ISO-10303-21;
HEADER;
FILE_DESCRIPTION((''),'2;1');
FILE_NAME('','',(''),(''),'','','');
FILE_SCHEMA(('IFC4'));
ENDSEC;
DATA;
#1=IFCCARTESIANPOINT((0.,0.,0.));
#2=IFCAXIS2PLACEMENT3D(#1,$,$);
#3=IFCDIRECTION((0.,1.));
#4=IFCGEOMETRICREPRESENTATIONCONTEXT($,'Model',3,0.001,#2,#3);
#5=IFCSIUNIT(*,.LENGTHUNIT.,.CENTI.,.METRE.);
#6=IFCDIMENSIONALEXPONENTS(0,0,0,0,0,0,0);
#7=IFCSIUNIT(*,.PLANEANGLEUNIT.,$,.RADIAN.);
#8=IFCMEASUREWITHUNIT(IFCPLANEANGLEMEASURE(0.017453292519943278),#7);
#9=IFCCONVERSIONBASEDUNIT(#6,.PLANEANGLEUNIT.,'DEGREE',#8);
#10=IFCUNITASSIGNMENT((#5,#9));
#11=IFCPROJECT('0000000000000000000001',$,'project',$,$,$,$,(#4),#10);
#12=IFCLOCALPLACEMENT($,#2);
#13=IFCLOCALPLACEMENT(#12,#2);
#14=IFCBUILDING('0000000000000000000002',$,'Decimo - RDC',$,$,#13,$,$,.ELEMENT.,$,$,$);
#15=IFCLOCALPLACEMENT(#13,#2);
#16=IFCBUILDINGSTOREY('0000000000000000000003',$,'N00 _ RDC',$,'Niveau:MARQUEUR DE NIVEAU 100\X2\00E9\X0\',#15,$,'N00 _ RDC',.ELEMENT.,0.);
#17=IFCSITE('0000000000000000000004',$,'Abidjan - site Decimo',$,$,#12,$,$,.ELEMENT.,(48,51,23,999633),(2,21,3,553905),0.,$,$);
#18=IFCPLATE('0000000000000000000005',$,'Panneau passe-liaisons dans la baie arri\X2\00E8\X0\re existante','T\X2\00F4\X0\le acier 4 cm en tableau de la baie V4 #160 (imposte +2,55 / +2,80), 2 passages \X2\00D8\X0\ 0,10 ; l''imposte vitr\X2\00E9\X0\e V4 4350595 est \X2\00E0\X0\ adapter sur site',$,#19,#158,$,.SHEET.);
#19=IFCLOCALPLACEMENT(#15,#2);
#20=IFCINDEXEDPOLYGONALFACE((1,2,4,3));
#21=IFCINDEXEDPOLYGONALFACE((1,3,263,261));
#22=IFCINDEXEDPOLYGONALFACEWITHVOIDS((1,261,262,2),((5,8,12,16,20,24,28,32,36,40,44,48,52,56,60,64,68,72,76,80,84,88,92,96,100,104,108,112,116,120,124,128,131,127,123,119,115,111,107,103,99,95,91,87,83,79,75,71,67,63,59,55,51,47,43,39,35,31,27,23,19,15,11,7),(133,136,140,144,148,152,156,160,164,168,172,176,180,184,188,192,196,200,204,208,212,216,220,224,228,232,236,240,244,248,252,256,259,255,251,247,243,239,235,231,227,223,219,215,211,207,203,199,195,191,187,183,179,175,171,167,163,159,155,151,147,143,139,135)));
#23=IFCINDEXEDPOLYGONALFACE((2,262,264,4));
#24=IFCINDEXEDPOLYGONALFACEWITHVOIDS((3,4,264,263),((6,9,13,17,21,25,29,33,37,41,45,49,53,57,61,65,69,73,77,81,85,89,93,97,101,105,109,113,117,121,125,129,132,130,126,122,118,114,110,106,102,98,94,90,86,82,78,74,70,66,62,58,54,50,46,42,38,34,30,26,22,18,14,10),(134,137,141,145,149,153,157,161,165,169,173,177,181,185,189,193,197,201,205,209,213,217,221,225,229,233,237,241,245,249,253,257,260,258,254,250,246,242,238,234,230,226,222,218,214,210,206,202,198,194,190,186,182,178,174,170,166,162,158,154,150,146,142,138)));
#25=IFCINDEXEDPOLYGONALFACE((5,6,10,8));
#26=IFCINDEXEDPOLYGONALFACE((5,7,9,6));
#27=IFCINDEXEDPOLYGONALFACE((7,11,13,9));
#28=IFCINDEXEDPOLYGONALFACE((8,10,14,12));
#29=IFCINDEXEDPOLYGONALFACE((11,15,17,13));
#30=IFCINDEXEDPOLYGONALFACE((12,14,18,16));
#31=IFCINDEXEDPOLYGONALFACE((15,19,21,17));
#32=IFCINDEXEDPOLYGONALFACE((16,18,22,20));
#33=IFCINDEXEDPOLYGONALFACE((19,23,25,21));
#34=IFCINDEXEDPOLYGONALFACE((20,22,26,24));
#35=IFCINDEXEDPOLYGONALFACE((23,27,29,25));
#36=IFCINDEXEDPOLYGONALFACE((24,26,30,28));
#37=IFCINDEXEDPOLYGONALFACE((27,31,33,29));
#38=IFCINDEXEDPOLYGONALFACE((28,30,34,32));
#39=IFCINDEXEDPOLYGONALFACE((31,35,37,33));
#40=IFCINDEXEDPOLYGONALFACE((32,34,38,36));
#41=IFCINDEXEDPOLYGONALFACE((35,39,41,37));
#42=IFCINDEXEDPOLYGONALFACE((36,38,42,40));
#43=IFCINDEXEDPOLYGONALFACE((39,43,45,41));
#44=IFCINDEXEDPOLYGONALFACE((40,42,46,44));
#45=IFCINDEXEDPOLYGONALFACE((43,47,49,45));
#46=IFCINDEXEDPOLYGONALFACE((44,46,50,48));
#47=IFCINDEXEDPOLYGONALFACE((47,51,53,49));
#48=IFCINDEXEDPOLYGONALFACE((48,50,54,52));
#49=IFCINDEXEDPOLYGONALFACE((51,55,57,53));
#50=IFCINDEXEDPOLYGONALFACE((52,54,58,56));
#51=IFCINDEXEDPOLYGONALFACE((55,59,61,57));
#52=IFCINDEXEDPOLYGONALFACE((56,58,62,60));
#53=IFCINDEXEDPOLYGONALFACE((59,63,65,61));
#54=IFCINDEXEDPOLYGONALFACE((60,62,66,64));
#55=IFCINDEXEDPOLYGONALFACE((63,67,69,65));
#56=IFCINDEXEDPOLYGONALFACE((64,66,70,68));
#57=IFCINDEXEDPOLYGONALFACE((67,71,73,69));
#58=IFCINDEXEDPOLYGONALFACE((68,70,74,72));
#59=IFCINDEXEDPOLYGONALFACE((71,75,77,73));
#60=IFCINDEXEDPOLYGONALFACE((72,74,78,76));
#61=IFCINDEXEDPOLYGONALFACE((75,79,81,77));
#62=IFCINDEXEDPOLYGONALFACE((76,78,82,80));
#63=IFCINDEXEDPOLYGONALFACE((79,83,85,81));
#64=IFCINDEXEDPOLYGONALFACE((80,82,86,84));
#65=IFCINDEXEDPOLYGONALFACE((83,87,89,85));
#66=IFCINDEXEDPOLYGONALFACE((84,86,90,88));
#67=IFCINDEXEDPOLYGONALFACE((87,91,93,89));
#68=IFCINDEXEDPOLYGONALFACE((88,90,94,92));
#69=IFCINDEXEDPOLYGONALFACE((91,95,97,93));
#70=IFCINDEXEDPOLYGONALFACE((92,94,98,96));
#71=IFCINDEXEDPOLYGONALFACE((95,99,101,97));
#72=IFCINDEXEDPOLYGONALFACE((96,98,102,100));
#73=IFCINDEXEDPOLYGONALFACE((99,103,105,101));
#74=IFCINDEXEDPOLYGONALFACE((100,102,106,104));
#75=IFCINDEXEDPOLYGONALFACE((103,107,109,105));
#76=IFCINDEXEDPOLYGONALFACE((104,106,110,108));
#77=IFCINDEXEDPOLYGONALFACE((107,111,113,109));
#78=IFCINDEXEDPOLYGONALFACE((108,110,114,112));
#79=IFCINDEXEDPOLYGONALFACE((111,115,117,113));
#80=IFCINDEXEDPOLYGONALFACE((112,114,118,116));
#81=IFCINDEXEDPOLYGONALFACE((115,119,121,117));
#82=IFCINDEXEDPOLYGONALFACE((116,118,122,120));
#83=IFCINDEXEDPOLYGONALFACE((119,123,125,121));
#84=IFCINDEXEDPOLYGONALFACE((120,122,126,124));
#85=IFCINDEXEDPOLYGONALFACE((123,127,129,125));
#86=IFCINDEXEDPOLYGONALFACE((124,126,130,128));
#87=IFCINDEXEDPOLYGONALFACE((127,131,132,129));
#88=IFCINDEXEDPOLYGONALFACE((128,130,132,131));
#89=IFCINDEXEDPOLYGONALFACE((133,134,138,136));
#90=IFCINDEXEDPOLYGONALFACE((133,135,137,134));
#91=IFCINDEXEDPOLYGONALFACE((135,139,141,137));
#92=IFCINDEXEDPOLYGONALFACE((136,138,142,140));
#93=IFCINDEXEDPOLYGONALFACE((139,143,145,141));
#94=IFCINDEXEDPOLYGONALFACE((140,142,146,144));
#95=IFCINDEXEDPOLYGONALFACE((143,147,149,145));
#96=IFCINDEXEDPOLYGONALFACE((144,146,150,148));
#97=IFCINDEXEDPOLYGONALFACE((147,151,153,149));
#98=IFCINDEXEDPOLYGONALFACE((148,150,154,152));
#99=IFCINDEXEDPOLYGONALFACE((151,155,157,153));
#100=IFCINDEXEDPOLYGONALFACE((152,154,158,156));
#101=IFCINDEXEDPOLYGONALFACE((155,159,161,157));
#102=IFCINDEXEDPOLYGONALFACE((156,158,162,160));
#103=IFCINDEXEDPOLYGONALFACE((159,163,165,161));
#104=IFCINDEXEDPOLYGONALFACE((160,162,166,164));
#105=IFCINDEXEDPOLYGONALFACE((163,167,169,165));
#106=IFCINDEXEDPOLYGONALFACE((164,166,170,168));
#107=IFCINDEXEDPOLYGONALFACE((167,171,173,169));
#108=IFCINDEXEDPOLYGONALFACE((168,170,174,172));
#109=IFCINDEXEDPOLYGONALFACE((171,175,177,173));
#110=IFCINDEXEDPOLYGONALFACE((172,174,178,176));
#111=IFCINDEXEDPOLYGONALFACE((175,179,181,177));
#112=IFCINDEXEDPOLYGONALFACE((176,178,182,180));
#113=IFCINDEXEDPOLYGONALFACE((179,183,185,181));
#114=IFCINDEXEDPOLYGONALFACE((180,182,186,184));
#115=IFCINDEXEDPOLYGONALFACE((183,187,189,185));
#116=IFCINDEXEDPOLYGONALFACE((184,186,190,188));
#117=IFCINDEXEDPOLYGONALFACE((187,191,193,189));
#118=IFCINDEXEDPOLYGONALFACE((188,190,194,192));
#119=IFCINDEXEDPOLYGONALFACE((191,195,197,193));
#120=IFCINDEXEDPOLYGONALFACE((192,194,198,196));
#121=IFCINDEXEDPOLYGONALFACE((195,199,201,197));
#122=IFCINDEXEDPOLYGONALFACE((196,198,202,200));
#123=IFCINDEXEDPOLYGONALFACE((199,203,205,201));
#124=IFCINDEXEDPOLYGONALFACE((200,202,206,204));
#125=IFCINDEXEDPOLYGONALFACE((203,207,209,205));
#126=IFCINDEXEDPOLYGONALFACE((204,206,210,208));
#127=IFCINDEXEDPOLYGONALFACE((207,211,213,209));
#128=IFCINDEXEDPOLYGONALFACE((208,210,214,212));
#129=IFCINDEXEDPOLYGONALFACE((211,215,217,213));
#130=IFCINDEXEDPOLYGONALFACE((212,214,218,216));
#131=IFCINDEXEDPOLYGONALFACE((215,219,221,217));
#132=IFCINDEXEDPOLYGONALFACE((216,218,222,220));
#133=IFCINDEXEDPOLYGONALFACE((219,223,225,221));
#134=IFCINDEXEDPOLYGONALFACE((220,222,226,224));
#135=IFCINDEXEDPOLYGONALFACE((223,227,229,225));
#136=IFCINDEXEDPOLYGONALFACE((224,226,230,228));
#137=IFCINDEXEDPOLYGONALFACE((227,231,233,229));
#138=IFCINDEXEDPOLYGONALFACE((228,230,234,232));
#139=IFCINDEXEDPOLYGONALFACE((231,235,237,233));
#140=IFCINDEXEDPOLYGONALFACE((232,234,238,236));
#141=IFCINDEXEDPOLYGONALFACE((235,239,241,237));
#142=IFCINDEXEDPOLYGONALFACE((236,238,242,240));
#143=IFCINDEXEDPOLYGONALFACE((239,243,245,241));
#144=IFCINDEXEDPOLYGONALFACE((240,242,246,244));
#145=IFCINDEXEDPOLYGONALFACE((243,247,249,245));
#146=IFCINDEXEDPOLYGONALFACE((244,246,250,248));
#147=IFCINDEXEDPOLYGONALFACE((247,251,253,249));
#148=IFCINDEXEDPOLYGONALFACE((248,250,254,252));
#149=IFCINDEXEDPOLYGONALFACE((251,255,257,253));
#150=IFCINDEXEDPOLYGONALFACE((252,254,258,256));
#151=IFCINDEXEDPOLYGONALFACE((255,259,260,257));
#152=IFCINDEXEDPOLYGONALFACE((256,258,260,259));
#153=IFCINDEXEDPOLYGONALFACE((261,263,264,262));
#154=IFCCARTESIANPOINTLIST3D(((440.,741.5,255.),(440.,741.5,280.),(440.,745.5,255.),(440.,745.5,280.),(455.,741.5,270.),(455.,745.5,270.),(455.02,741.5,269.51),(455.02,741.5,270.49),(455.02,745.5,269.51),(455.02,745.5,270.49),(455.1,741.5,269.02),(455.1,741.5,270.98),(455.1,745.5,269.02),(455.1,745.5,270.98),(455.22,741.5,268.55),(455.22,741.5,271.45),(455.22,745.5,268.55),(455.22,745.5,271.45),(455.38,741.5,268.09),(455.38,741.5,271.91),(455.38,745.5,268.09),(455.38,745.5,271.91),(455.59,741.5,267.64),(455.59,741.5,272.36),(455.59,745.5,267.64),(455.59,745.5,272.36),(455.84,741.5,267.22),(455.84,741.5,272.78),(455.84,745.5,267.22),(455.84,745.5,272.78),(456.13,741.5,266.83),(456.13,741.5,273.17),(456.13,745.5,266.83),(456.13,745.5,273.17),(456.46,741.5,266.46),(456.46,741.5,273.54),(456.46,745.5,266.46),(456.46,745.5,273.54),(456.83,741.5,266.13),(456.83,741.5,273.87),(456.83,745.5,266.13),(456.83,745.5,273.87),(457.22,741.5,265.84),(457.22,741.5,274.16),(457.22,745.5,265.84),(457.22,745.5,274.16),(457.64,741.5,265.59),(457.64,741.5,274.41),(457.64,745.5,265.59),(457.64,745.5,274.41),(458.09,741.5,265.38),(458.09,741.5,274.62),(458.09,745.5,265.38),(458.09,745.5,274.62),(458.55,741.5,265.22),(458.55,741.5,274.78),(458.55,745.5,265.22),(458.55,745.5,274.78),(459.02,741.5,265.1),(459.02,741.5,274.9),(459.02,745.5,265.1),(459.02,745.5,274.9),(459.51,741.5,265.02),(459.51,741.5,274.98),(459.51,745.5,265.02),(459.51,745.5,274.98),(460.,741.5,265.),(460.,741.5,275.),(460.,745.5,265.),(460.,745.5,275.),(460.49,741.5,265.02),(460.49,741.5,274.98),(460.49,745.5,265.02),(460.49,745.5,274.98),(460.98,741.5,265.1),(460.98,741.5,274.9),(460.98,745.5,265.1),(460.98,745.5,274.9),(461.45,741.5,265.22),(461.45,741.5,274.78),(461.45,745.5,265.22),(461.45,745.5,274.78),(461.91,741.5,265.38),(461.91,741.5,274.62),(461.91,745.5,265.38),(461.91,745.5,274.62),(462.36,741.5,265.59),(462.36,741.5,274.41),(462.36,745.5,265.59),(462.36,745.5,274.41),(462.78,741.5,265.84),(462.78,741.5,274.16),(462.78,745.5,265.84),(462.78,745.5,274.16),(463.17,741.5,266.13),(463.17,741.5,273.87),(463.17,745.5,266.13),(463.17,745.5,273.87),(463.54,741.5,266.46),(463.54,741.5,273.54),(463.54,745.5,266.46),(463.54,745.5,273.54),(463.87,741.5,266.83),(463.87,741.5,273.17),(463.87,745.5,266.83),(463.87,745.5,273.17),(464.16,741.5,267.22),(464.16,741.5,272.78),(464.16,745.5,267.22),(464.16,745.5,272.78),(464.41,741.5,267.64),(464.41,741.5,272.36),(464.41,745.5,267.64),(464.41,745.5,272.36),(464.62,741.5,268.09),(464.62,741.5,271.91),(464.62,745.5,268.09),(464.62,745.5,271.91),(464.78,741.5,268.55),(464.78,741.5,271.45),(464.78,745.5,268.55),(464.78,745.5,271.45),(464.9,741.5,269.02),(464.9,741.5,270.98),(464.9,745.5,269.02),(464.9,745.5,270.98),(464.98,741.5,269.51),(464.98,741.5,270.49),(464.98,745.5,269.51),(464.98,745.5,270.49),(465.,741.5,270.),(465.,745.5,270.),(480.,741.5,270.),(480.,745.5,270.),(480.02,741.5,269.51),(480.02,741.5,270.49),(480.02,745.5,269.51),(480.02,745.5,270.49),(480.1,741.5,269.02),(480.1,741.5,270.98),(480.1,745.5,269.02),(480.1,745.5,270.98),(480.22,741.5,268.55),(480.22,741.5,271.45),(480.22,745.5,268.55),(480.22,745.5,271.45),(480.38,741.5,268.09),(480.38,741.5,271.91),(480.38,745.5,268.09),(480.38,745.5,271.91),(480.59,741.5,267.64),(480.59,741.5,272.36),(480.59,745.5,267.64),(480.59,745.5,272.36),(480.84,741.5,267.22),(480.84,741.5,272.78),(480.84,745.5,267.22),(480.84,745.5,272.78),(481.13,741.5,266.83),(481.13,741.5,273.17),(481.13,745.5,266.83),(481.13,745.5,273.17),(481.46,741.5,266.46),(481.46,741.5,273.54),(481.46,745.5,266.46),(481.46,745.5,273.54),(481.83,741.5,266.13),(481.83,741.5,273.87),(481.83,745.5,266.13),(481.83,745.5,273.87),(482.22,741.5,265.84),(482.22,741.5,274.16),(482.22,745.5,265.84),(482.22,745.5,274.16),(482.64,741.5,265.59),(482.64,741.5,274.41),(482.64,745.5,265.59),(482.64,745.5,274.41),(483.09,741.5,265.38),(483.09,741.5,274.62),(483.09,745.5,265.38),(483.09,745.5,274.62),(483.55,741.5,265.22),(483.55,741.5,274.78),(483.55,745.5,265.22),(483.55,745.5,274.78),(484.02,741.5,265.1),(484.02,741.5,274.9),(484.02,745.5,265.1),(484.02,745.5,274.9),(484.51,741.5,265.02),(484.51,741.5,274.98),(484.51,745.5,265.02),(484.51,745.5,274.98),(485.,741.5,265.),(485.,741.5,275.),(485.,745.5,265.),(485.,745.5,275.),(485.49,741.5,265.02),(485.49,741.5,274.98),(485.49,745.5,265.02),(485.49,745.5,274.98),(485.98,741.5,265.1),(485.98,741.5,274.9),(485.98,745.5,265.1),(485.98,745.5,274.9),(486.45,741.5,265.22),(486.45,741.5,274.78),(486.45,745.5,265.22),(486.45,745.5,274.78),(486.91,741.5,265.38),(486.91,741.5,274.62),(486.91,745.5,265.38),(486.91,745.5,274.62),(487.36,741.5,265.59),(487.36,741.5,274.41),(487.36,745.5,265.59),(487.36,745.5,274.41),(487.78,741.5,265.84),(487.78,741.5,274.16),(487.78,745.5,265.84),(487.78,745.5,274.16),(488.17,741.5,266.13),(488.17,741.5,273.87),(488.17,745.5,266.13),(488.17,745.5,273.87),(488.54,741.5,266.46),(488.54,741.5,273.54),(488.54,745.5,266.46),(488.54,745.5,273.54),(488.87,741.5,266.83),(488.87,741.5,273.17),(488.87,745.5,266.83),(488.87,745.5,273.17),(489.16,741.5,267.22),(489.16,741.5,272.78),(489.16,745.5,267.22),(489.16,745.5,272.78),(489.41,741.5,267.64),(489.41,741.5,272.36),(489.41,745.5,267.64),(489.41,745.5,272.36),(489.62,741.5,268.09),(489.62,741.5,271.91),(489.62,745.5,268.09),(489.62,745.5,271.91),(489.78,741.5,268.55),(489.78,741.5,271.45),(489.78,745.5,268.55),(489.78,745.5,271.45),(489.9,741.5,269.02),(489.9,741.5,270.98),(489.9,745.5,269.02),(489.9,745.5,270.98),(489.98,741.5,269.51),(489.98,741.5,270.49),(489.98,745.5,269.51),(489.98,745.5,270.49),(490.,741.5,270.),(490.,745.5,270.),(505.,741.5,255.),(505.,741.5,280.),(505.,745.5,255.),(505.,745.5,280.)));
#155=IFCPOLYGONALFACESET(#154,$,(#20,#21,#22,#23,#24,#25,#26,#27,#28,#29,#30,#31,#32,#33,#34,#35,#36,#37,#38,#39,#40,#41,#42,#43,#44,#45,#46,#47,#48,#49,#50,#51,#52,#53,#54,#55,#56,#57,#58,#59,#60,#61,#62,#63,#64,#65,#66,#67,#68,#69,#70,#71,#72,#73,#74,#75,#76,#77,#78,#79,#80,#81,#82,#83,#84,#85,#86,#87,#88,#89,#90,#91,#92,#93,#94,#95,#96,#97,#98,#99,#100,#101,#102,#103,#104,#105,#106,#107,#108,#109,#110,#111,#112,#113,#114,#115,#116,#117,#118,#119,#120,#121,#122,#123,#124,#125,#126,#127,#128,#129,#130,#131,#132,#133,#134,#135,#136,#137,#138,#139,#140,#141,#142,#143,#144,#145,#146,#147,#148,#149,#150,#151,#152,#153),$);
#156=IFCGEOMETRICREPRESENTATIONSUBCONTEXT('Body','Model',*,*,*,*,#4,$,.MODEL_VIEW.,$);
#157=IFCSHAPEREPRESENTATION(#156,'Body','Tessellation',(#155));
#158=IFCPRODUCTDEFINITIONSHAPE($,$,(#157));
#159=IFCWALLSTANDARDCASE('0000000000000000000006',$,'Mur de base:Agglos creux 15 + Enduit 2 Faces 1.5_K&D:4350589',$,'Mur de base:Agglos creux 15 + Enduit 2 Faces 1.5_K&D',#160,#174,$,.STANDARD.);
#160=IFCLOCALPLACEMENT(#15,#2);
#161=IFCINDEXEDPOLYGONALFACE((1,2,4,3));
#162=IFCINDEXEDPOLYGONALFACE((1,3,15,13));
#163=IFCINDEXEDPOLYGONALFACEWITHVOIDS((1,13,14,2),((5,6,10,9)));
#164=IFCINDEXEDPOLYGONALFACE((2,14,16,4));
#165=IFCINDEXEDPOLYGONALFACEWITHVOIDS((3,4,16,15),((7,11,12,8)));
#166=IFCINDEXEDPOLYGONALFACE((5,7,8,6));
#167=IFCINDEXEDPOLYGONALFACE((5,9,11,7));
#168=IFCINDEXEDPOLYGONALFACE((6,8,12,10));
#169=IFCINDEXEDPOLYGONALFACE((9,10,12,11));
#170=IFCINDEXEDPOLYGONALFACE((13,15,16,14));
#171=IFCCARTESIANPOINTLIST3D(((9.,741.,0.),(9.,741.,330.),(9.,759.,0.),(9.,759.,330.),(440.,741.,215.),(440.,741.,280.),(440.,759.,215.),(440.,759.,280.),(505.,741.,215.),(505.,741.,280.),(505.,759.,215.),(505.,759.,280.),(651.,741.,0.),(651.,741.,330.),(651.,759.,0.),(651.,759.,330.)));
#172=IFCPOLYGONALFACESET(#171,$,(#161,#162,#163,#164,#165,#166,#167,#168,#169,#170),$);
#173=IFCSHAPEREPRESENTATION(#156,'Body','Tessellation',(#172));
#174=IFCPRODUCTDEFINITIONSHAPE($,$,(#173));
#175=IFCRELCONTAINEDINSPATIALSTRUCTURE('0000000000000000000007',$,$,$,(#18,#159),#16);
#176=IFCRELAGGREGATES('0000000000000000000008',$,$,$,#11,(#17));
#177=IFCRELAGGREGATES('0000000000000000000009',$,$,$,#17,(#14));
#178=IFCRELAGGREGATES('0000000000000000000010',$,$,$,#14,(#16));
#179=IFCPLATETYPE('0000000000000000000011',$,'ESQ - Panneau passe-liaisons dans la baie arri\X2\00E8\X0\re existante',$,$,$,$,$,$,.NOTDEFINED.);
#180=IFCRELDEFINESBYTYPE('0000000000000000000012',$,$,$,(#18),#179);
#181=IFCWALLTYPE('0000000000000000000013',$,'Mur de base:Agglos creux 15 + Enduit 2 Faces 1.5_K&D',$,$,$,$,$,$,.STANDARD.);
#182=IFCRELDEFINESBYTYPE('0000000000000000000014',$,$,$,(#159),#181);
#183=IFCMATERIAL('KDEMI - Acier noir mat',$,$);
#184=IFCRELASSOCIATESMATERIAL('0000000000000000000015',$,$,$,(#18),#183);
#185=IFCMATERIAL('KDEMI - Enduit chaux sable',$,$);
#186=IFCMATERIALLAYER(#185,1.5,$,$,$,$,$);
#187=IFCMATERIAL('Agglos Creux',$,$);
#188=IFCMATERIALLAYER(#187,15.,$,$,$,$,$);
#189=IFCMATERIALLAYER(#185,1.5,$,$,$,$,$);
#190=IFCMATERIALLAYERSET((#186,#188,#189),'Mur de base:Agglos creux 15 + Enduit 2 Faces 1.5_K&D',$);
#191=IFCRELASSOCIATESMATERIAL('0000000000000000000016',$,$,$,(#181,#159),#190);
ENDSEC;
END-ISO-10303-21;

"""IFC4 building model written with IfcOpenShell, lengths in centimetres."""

from ifc_helpers import new_model, entity, si_unit, converted_unit, direction, frame, frame_2d, origin, origin_with_axes, place, context, subcontext, project, spatial, polyline, rectangle, outline, extrude, material, layer, layer_set, layer_usage, type_object, element, save


model = new_model("IFC4")

# Units and contexts
model_context = context("Model", 3, precision=0.001, world=origin(), true_north=direction((0.0, 1.0)))
body_context = subcontext(model_context, "Body", "Model", "MODEL_VIEW")
ifc_project = project(units=[si_unit("LENGTHUNIT", "METRE", prefix="CENTI"), converted_unit("PLANEANGLEUNIT", "DEGREE", entity("IfcPlaneAngleMeasure", 0.017453292519943278), si_unit("PLANEANGLEUNIT", "RADIAN"), dimensions=[0, 0, 0, 0, 0, 0, 0])], contexts=[model_context])

# Site, building, storey
site_placement = place(None, origin())
site = spatial("IfcSite", under=ifc_project, at=site_placement, Name="Abidjan - site Decimo", CompositionType="ELEMENT", RefLatitude=(48, 51, 23, 999633), RefLongitude=(2, 21, 3, 553905), RefElevation=0.0)
building_placement = place(site_placement, origin())
building = spatial("IfcBuilding", under=site, at=building_placement, Name="Decimo - RDC", CompositionType="ELEMENT")
storey_placement = place(building_placement, origin())
storey = spatial("IfcBuildingStorey", under=building, at=storey_placement, Name="N00 _ RDC", ObjectType="Niveau:MARQUEUR DE NIVEAU 100é", LongName="N00 _ RDC", CompositionType="ELEMENT", Elevation=0.0)

# Plate
ifc_material_1 = material(Name="KDEMI - Acier noir mat")
plate_type = type_object("IfcPlateType", Name="ESQ - Panneau passe-liaisons dans la baie arrière existante", PredefinedType="NOTDEFINED")
plate_placement = place(storey_placement, origin_with_axes())
element("IfcPlate", 1, at=plate_placement, inside=storey, type_object=plate_type, material=ifc_material_1, Name="Panneau passe-liaisons dans la baie arrière existante", Description="Tôle acier 4 cm en tableau de la baie V4 #160 (imposte +2,55 / +2,80), 2 passages Ø 0,10 ; l'imposte vitrée V4 4350595 est à adapter sur site", PredefinedType="SHEET", context=body_context, shape_type="SweptSolid", body=[
    extrude(outline(polyline([(440.0, 255.0), (440.0, 280.0), (505.0, 280.0), (505.0, 255.0), (440.0, 255.0)]), holes=[polyline([(490.0, 270.0), (489.98, 270.49), (489.9, 270.98), (489.78, 271.45), (489.62, 271.91), (489.41, 272.36), (489.16, 272.78), (488.87, 273.17), (488.54, 273.54), (488.17, 273.87), (487.78, 274.16), (487.36, 274.41), (486.91, 274.62), (486.45, 274.78), (485.98, 274.9), (485.49, 274.98), (485.0, 275.0), (484.51, 274.98), (484.02, 274.9), (483.55, 274.78), (483.09, 274.62), (482.64, 274.41), (482.22, 274.16), (481.83, 273.87), (481.46, 273.54), (481.13, 273.17), (480.84, 272.78), (480.59, 272.36), (480.38, 271.91), (480.22, 271.45), (480.1, 270.98), (480.02, 270.49), (480.0, 270.0), (480.02, 269.51), (480.1, 269.02), (480.22, 268.55), (480.38, 268.09), (480.59, 267.64), (480.84, 267.22), (481.13, 266.83), (481.46, 266.46), (481.83, 266.13), (482.22, 265.84), (482.64, 265.59), (483.09, 265.38), (483.55, 265.22), (484.02, 265.1), (484.51, 265.02), (485.0, 265.0), (485.49, 265.02), (485.98, 265.1), (486.45, 265.22), (486.91, 265.38), (487.36, 265.59), (487.78, 265.84), (488.17, 266.13), (488.54, 266.46), (488.87, 266.83), (489.16, 267.22), (489.41, 267.64), (489.62, 268.09), (489.78, 268.55), (489.9, 269.02), (489.98, 269.51), (490.0, 270.0)]), polyline([(465.0, 270.0), (464.98, 270.49), (464.9, 270.98), (464.78, 271.45), (464.62, 271.91), (464.41, 272.36), (464.16, 272.78), (463.87, 273.17), (463.54, 273.54), (463.17, 273.87), (462.78, 274.16), (462.36, 274.41), (461.91, 274.62), (461.45, 274.78), (460.98, 274.9), (460.49, 274.98), (460.0, 275.0), (459.51, 274.98), (459.02, 274.9), (458.55, 274.78), (458.09, 274.62), (457.64, 274.41), (457.22, 274.16), (456.83, 273.87), (456.46, 273.54), (456.13, 273.17), (455.84, 272.78), (455.59, 272.36), (455.38, 271.91), (455.22, 271.45), (455.1, 270.98), (455.02, 270.49), (455.0, 270.0), (455.02, 269.51), (455.1, 269.02), (455.22, 268.55), (455.38, 268.09), (455.59, 267.64), (455.84, 267.22), (456.13, 266.83), (456.46, 266.46), (456.83, 266.13), (457.22, 265.84), (457.64, 265.59), (458.09, 265.38), (458.55, 265.22), (459.02, 265.1), (459.51, 265.02), (460.0, 265.0), (460.49, 265.02), (460.98, 265.1), (461.45, 265.22), (461.91, 265.38), (462.36, 265.59), (462.78, 265.84), (463.17, 266.13), (463.54, 266.46), (463.87, 266.83), (464.16, 267.22), (464.41, 267.64), (464.62, 268.09), (464.78, 268.55), (464.9, 269.02), (464.98, 269.51), (465.0, 270.0)])]), frame((0.0, 745.5, 0.0), z_axis=(0.0, -1.0, 0.0), x_axis=(1.0, 0.0, 0.0)), (0.0, 0.0, 1.0), 4.0),
])

# Wall, opening
ifc_material_2 = material(Name="KDEMI - Enduit chaux sable")
ifc_layer_1 = layer(ifc_material_2, 1.5)
ifc_material_3 = material(Name="Agglos Creux")
ifc_layer_2 = layer(ifc_material_3, 15.0)
ifc_layer_3 = layer(ifc_material_2, 1.5)
ifc_layer_set_1 = layer_set([ifc_layer_1, ifc_layer_2, ifc_layer_3], Name="Mur de base:Agglos creux 15 + Enduit 2 Faces 1.5_K&D")
ifc_layer_usage_1 = layer_usage(ifc_layer_set_1, "AXIS2", "NEGATIVE", 9.0)
wall_type_1 = type_object("IfcWallType", Name="Mur de base:Agglos creux 15 + Enduit 2 Faces 1.5_K&D", PredefinedType="STANDARD", material=ifc_layer_set_1)
wall_1_placement = place(storey_placement, frame((9.0, 750.0, 0.0)))
wall_1 = element("IfcWallStandardCase", 2, at=wall_1_placement, inside=storey, type_object=wall_type_1, material=ifc_layer_usage_1, Name="Mur de base:Agglos creux 15 + Enduit 2 Faces 1.5_K&D:4350589", ObjectType="Mur de base:Agglos creux 15 + Enduit 2 Faces 1.5_K&D", PredefinedType="STANDARD", context=body_context, shape_type="SweptSolid", body=[
    extrude(rectangle(XDim=642.0, YDim=18.0, at=frame_2d((321.0, 0.0), x_axis=(-1.0, 0.0))), origin(), (0.0, 0.0, 1.0), 330.0),
])
opening_1_placement = place(wall_1_placement, origin())
element("IfcOpeningElement", 3, at=opening_1_placement, cuts=wall_1, ObjectType="Opening", context=body_context, shape_type="SweptSolid", body=[
    extrude(rectangle(XDim=65.0, YDim=65.0, at=frame_2d((0.0, 0.0), x_axis=(1.0, 0.0))), frame((463.5, -9.0, 247.5), z_axis=(0.0, 1.0, 0.0), x_axis=(0.0, 0.0, -1.0)), (0.0, 0.0, 1.0), 18.0),
])

save(model, "model.ifc")
